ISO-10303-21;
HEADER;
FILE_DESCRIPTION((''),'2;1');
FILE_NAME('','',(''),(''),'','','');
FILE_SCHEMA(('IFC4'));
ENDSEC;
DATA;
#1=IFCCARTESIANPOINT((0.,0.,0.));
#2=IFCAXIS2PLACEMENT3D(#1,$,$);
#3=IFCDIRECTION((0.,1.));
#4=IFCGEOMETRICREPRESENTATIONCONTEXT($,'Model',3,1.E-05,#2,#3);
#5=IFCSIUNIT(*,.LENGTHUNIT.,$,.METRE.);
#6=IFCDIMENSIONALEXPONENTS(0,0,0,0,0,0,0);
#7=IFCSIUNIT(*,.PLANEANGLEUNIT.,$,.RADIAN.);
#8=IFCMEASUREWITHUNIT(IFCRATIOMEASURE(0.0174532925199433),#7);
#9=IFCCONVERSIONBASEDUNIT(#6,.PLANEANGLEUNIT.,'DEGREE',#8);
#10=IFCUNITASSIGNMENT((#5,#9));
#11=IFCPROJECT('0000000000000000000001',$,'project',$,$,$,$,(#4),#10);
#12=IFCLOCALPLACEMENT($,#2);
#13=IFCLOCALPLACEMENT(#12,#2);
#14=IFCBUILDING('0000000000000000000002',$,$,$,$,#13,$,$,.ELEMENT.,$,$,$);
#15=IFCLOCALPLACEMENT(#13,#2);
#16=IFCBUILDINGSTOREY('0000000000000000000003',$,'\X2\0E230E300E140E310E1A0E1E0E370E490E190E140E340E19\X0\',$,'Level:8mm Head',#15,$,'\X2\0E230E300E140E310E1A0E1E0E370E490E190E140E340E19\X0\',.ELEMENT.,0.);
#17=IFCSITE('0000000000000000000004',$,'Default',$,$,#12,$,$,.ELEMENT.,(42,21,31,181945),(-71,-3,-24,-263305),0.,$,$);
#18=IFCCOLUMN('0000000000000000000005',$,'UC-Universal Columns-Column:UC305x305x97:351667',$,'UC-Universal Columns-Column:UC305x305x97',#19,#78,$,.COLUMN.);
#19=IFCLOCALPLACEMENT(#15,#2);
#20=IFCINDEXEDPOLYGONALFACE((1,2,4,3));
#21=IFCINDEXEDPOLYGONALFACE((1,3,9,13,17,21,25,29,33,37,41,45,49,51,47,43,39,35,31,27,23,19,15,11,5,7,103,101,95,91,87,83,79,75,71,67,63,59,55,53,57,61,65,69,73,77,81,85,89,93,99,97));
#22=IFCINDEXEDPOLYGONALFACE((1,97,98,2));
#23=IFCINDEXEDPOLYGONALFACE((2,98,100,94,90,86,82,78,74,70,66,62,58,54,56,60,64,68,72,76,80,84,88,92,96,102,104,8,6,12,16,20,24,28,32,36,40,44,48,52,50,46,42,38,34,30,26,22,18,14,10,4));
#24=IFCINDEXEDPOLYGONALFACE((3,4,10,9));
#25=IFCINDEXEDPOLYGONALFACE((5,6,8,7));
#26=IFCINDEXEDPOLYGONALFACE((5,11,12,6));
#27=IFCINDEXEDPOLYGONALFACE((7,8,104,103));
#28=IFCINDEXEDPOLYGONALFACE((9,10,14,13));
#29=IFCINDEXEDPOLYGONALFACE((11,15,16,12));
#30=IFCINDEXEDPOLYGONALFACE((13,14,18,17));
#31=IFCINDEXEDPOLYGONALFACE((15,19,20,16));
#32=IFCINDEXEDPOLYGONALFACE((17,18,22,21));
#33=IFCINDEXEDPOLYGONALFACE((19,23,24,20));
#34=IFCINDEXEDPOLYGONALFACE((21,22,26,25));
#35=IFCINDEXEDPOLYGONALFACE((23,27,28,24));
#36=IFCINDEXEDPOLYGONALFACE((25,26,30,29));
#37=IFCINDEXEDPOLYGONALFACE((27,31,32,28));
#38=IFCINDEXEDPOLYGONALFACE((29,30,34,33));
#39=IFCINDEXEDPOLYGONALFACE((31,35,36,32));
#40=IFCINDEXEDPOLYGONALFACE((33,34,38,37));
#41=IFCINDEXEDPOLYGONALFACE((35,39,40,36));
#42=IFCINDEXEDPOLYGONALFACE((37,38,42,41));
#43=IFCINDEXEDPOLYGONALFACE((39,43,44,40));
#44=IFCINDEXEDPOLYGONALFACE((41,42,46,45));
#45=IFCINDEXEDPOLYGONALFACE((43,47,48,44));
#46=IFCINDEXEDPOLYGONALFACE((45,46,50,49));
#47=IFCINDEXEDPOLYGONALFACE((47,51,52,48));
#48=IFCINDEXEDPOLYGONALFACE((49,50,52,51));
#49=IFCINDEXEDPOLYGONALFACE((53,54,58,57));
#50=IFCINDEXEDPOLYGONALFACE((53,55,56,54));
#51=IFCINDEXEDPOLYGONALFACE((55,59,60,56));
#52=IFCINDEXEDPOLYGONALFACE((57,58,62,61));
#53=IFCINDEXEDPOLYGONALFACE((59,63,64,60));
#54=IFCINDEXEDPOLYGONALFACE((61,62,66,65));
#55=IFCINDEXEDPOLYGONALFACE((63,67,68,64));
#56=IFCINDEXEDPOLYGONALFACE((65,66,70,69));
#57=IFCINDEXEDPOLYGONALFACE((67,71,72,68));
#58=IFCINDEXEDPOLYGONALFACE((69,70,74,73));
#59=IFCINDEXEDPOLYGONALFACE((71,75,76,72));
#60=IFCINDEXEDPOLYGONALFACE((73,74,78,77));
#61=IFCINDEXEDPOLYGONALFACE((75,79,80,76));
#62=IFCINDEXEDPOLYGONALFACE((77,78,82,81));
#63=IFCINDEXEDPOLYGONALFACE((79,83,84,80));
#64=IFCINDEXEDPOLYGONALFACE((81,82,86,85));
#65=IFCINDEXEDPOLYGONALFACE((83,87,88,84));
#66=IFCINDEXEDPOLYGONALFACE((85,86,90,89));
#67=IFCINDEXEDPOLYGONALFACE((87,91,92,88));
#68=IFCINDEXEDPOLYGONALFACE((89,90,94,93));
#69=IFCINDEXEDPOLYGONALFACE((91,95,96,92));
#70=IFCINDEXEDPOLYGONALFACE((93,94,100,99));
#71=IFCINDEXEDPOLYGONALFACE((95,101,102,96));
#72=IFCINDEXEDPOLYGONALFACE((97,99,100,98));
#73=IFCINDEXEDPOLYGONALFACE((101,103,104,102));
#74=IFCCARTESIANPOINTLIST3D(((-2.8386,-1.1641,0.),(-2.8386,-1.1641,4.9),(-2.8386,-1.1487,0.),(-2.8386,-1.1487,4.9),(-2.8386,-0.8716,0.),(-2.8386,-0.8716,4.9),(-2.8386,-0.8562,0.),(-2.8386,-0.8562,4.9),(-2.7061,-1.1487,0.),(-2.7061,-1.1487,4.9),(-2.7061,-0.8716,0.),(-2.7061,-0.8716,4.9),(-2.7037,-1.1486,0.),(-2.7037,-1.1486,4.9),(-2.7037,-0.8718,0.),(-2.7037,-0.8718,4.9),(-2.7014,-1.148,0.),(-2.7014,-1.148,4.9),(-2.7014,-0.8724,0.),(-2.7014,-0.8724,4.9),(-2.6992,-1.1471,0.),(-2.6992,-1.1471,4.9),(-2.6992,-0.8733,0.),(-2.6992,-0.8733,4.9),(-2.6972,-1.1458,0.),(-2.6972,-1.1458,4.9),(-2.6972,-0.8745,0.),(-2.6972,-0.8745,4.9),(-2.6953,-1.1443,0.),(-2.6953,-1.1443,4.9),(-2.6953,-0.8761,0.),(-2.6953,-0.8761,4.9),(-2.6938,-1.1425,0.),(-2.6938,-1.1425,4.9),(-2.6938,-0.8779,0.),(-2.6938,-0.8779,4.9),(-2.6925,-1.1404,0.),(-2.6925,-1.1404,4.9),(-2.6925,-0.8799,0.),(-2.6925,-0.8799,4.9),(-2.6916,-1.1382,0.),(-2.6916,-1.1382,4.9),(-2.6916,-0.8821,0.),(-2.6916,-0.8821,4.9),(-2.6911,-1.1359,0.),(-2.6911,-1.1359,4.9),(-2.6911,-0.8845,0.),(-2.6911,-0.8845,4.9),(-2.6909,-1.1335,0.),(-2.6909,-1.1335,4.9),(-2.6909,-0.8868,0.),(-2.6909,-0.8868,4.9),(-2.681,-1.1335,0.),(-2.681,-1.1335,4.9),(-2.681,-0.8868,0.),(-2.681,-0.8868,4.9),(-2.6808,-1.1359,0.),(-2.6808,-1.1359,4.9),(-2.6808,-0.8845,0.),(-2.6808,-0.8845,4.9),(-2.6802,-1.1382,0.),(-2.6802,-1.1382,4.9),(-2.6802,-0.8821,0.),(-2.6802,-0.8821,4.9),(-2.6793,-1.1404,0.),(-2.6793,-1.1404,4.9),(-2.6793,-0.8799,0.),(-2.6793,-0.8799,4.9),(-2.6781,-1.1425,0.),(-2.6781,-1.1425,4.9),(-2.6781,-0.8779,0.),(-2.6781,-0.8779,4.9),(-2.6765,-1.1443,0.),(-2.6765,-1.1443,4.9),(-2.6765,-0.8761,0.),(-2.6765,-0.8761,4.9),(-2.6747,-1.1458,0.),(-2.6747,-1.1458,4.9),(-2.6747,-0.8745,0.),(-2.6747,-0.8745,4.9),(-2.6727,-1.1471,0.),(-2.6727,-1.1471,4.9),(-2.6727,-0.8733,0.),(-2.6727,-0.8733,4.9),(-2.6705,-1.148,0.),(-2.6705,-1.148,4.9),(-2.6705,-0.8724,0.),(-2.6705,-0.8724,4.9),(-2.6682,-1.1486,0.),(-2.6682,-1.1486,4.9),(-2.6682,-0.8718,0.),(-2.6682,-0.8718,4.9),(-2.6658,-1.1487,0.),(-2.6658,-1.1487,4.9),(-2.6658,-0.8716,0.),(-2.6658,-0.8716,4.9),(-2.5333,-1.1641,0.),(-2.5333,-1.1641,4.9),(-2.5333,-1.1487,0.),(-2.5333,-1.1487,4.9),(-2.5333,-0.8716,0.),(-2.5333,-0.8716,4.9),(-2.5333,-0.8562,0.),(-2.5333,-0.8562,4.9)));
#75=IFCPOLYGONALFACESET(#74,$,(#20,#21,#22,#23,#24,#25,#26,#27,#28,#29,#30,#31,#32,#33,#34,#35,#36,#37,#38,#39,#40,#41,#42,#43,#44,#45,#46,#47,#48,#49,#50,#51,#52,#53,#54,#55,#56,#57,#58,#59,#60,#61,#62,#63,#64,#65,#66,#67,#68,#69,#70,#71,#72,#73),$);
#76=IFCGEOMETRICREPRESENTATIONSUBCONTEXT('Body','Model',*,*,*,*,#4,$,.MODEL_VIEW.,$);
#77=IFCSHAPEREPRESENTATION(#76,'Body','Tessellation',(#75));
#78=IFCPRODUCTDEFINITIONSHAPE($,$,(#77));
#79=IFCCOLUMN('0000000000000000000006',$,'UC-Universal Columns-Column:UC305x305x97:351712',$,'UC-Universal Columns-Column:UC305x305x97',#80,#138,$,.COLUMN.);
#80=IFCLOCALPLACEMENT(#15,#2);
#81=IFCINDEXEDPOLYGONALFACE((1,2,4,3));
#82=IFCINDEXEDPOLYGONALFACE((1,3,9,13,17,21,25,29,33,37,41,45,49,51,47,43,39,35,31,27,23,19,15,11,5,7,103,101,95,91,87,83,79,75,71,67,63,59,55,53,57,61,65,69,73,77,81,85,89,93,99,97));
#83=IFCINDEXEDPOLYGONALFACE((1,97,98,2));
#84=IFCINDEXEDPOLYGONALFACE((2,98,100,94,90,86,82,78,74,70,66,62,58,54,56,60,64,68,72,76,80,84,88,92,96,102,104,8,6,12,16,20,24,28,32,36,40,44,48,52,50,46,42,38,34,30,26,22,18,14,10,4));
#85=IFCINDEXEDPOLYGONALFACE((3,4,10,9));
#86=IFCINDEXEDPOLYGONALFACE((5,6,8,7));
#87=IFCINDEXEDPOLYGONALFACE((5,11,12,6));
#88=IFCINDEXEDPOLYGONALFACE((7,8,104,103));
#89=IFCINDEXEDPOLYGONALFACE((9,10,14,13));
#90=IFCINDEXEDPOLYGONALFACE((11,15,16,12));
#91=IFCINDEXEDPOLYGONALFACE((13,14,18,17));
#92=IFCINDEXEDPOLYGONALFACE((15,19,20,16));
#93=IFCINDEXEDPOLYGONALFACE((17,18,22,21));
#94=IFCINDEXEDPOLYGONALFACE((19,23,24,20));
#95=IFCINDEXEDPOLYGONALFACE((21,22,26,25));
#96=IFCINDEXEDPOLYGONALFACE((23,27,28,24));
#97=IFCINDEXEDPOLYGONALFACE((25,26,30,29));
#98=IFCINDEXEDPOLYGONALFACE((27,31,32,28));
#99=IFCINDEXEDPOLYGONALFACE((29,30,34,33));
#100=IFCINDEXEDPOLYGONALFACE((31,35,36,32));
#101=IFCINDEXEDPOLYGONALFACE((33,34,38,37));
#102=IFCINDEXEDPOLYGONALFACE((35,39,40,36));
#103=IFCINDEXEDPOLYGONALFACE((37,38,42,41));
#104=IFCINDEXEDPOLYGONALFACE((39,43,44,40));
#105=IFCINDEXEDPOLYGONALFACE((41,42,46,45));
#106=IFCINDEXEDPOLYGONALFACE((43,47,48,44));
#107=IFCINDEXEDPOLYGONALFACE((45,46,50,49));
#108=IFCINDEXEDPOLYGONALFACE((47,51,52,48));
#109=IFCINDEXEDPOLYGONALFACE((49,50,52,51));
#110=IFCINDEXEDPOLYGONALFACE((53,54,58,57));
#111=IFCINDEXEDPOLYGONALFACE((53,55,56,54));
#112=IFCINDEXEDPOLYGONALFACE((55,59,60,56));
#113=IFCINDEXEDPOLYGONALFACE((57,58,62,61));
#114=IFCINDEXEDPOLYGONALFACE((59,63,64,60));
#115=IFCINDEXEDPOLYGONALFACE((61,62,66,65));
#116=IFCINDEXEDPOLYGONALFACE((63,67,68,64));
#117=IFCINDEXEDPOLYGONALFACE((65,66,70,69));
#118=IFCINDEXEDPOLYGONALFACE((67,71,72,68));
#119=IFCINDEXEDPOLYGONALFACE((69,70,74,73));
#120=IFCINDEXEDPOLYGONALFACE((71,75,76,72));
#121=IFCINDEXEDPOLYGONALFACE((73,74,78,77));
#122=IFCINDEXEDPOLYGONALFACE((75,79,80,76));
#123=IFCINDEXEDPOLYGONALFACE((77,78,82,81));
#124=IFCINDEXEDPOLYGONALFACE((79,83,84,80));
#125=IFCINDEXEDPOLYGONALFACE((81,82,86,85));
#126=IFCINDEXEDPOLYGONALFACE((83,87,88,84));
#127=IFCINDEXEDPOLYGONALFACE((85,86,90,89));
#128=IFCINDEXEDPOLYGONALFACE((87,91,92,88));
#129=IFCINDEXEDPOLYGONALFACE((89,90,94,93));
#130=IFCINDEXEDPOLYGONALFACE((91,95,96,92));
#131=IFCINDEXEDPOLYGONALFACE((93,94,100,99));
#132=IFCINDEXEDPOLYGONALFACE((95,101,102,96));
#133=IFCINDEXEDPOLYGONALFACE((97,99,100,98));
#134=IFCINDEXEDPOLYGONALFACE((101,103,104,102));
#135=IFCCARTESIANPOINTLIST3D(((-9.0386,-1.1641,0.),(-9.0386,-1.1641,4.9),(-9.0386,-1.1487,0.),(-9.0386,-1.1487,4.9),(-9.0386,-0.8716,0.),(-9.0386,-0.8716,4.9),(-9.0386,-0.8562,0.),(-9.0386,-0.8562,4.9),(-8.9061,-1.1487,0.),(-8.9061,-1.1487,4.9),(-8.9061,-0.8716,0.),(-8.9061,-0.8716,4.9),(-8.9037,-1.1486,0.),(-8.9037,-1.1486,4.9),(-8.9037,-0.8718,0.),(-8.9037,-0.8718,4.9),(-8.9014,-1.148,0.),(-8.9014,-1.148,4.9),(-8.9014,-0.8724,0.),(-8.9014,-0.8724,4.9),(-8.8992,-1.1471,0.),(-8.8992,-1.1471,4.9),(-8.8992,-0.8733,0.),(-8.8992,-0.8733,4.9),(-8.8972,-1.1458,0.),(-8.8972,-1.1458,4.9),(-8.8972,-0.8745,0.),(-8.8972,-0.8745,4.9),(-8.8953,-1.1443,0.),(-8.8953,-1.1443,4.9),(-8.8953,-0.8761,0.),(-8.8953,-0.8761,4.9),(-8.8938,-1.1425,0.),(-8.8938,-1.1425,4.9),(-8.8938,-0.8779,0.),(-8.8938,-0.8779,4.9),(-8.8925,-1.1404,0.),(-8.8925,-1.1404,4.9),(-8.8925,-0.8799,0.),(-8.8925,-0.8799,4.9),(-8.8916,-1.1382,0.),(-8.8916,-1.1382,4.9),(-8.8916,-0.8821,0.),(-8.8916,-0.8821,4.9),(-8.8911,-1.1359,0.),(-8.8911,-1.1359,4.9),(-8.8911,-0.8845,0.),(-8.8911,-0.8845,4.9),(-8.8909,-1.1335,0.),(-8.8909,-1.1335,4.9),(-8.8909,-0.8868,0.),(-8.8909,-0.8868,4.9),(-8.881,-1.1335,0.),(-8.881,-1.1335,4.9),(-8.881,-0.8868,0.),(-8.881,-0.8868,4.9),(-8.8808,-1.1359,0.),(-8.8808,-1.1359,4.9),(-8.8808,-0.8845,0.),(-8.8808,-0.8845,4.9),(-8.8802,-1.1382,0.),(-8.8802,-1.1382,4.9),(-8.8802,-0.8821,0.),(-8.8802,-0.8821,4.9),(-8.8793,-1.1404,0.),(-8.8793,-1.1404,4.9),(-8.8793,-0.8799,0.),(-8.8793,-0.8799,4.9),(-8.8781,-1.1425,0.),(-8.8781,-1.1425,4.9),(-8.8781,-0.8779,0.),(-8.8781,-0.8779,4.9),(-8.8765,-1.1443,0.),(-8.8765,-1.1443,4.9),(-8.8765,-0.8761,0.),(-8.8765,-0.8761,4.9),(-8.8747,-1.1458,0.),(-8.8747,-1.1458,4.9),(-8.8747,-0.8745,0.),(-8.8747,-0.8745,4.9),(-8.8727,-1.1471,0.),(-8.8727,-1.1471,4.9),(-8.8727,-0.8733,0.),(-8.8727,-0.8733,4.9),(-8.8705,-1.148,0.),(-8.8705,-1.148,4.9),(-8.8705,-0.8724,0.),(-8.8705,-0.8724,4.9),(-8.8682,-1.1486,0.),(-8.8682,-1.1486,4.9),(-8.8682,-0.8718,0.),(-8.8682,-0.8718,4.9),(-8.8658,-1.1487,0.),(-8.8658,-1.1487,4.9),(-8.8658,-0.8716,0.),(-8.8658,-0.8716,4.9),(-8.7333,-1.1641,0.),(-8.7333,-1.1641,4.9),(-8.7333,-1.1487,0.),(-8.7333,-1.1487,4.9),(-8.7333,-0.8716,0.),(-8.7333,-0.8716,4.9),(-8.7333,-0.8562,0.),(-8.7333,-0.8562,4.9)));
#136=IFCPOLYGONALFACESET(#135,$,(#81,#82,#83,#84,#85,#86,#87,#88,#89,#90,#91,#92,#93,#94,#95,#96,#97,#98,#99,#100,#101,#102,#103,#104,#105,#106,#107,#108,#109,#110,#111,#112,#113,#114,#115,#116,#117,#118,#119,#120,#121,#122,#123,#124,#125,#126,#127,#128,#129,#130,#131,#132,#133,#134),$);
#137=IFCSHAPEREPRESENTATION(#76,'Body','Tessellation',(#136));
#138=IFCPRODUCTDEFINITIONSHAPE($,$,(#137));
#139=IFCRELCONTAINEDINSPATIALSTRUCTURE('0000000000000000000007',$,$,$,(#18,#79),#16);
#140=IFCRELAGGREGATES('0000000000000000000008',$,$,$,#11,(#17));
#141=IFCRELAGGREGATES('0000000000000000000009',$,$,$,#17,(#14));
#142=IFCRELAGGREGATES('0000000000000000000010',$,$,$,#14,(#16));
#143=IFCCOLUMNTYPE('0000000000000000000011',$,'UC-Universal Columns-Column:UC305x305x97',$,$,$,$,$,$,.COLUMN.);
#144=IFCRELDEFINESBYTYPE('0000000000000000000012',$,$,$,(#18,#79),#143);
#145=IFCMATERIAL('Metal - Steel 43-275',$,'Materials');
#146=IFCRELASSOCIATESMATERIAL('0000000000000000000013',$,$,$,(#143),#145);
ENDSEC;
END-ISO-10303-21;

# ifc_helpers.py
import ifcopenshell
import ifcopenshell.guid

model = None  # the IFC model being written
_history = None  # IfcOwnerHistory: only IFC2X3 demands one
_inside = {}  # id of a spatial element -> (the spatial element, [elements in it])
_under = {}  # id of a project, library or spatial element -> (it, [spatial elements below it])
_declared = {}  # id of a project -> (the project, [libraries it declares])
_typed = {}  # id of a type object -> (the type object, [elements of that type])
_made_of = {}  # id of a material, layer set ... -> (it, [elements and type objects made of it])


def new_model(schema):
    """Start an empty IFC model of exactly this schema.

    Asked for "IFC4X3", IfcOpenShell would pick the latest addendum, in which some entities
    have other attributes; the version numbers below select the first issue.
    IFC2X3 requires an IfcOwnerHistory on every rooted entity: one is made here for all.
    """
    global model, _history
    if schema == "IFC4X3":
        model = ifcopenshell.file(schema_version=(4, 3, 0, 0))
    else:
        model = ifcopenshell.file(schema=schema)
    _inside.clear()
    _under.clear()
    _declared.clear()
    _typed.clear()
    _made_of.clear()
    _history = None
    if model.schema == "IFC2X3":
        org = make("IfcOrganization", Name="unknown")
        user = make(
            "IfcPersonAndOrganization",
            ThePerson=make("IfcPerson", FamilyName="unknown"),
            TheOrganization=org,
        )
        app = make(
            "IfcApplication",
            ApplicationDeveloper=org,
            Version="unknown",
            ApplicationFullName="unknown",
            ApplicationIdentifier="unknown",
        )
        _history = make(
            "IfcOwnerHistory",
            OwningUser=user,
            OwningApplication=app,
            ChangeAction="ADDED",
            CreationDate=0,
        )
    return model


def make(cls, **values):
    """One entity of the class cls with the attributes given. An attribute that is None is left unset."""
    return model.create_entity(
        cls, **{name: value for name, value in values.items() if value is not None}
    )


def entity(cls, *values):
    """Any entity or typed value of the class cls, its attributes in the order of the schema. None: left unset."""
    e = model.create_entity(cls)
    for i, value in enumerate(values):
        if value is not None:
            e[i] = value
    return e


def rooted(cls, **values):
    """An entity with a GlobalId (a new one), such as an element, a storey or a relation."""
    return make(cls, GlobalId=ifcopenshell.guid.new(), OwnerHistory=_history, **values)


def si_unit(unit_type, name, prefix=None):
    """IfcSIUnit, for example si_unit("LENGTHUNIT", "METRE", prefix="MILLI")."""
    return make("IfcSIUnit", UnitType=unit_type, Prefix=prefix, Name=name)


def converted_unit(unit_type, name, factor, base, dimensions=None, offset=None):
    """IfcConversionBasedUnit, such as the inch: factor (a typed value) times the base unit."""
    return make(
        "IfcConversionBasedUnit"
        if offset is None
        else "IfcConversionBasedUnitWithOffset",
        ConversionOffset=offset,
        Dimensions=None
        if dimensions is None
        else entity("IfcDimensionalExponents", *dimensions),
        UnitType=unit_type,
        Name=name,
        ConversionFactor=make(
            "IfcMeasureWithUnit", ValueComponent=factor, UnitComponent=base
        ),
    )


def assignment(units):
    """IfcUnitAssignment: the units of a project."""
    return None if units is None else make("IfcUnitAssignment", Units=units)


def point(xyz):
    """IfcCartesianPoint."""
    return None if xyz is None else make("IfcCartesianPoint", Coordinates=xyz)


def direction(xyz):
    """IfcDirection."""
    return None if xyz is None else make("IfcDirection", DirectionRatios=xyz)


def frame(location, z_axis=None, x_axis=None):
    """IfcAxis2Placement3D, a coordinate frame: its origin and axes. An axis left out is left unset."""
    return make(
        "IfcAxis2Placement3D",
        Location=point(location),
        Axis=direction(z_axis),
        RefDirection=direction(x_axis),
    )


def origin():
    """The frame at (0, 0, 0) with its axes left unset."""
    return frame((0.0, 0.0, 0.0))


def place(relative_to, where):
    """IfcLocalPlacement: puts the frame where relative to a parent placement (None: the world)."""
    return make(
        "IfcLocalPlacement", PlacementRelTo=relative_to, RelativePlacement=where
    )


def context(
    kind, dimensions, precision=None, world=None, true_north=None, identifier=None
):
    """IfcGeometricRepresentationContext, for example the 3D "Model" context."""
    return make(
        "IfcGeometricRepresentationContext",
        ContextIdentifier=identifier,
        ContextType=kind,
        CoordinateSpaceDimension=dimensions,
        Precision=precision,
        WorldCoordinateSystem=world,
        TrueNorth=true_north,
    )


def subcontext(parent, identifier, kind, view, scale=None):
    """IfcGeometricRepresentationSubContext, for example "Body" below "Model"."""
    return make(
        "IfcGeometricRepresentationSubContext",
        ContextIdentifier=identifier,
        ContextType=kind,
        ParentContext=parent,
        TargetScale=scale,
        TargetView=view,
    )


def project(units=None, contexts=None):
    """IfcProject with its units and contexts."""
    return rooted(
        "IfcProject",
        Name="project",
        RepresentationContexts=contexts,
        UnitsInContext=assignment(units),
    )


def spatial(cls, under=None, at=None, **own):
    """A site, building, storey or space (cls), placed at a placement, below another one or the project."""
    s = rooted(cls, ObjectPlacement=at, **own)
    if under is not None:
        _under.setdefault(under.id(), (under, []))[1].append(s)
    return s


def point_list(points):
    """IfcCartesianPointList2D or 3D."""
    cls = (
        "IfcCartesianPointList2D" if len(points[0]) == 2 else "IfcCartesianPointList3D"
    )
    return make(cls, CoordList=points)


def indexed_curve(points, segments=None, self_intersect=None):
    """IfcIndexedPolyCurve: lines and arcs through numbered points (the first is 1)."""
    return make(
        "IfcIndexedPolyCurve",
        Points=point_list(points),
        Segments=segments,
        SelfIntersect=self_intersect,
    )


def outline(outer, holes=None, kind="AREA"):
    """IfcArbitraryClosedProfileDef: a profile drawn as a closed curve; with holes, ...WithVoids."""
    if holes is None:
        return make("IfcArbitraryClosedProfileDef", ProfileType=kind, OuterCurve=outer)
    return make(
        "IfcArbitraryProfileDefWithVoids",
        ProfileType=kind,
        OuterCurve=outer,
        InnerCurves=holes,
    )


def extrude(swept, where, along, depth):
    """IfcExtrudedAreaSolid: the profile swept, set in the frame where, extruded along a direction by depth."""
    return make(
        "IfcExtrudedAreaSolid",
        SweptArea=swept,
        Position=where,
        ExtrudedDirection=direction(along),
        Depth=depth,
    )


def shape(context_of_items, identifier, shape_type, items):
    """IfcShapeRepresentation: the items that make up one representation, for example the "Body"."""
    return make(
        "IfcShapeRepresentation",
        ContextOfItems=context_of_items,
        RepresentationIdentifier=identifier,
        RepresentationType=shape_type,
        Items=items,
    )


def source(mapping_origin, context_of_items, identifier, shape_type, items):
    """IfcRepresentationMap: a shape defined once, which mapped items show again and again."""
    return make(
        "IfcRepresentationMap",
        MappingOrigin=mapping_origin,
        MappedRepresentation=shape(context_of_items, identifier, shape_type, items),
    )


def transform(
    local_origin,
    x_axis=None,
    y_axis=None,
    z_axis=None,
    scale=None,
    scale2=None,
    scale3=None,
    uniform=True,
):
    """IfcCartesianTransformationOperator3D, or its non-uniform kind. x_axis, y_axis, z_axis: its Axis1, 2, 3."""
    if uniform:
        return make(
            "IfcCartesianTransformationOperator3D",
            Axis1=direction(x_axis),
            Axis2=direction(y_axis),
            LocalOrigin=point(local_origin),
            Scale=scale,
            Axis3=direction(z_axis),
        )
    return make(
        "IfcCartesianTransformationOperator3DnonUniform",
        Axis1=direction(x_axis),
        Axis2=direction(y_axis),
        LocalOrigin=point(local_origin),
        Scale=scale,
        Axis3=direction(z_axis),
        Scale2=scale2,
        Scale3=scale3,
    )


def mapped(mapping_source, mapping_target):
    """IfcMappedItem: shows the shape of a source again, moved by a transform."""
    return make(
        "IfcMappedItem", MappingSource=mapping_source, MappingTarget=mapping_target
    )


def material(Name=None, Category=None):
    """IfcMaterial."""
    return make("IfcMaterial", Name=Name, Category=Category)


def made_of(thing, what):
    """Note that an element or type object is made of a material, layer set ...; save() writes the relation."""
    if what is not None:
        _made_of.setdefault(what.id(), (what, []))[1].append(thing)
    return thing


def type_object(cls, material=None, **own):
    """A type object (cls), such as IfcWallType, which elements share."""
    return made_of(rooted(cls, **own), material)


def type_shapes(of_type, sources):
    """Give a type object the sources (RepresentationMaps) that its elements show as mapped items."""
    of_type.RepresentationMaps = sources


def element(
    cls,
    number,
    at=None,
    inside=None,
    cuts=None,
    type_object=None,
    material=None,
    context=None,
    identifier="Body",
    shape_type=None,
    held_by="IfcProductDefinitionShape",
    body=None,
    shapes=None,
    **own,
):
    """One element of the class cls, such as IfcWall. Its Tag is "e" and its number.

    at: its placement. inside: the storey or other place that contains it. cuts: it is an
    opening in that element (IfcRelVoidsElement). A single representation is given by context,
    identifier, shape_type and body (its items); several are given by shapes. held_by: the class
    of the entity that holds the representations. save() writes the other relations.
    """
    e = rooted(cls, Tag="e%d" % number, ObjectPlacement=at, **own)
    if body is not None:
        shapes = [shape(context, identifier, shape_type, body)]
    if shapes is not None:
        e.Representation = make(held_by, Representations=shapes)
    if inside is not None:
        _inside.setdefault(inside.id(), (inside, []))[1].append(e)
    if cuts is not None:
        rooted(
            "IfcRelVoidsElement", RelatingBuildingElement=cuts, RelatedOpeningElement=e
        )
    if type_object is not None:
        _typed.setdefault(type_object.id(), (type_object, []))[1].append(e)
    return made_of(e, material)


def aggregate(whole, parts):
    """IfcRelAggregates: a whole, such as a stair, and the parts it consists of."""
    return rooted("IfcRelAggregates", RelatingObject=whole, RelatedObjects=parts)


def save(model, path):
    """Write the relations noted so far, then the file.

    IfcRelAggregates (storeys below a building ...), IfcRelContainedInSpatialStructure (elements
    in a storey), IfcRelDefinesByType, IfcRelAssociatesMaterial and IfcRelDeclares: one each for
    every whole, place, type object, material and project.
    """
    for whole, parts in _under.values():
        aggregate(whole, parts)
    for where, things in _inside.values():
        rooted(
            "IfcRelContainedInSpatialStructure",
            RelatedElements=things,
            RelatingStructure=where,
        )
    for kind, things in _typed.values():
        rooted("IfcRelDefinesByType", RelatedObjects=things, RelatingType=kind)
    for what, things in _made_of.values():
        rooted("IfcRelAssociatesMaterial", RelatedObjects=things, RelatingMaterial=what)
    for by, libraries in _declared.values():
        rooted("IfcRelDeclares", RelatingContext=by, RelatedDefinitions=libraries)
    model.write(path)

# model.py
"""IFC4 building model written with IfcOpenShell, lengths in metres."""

from ifc_helpers import new_model, entity, si_unit, converted_unit, direction, frame, origin, place, context, subcontext, project, spatial, indexed_curve, outline, extrude, source, transform, mapped, material, type_object, type_shapes, element, save


model = new_model("IFC4")

# Units and contexts
model_context = context("Model", 3, precision=1e-05, world=origin(), true_north=direction((0.0, 1.0)))
body_context = subcontext(model_context, "Body", "Model", "MODEL_VIEW")
ifc_project = project(units=[si_unit("LENGTHUNIT", "METRE"), converted_unit("PLANEANGLEUNIT", "DEGREE", entity("IfcRatioMeasure", 0.0174532925199433), si_unit("PLANEANGLEUNIT", "RADIAN"), dimensions=[0, 0, 0, 0, 0, 0, 0])], contexts=[model_context])

# Site, building, storey
site_placement = place(None, origin())
site = spatial("IfcSite", under=ifc_project, at=site_placement, Name="Default", CompositionType="ELEMENT", RefLatitude=(42, 21, 31, 181945), RefLongitude=(-71, -3, -24, -263305), RefElevation=0.0)
building_placement = place(site_placement, origin())
building = spatial("IfcBuilding", under=site, at=building_placement, CompositionType="ELEMENT")
storey_placement = place(building_placement, origin())
storey = spatial("IfcBuildingStorey", under=building, at=storey_placement, Name="ระดับพื้นดิน", ObjectType="Level:8mm Head", LongName="ระดับพื้นดิน", CompositionType="ELEMENT", Elevation=0.0)

# Columns
ifc_material_1 = material(Name="Metal - Steel 43-275", Category="Materials")
column_type_1 = type_object("IfcColumnType", Name="UC-Universal Columns-Column:UC305x305x97", PredefinedType="COLUMN", material=ifc_material_1)
shared_shape_1 = source(origin(), body_context, "Body", "SweptSolid", [
    extrude(outline(indexed_curve([(-0.154, -0.1527), (-0.1386, -0.1527), (-0.1386, -0.0202), (-0.1384, -0.0178), (-0.1378, -0.0155), (-0.1369, -0.0132), (-0.1356, -0.0112), (-0.1341, -0.0094), (-0.1323, -0.0079), (-0.1303, -0.0066), (-0.128, -0.0057), (-0.1257, -0.0051), (-0.1234, -0.0049), (0.1234, -0.0049), (0.1257, -0.0051), (0.128, -0.0057), (0.1303, -0.0066), (0.1323, -0.0079), (0.1341, -0.0094), (0.1356, -0.0112), (0.1369, -0.0132), (0.1378, -0.0155), (0.1384, -0.0178), (0.1386, -0.0201), (0.1386, -0.1527), (0.154, -0.1527), (0.154, 0.1527), (0.1386, 0.1527), (0.1386, 0.0202), (0.1384, 0.0178), (0.1378, 0.0155), (0.1369, 0.0132), (0.1356, 0.0112), (0.1341, 0.0094), (0.1323, 0.0079), (0.1303, 0.0066), (0.128, 0.0057), (0.1257, 0.0051), (0.1234, 0.005), (-0.1234, 0.005), (-0.1257, 0.0051), (-0.128, 0.0057), (-0.1303, 0.0066), (-0.1323, 0.0079), (-0.1341, 0.0094), (-0.1356, 0.0112), (-0.1369, 0.0132), (-0.1378, 0.0155), (-0.1384, 0.0178), (-0.1386, 0.0202), (-0.1386, 0.1527), (-0.154, 0.1527), (-0.154, -0.1527)], self_intersect=False)), frame((0.0, 0.0, 0.0), z_axis=(0.0, 0.0, 1.0), x_axis=(0.0, -1.0, 0.0)), (0.0, 0.0, 1.0), 4.9),
])
type_shapes(column_type_1, [shared_shape_1])
for number, where, name in (
    (1, (-2.6859, -1.0102, 0.0), "UC-Universal Columns-Column:UC305x305x97:351667"),
    (2, (-8.8859, -1.0102, 0.0), "UC-Universal Columns-Column:UC305x305x97:351712"),
):
    element("IfcColumn", number, at=place(storey_placement, frame(where)), inside=storey, type_object=column_type_1, Name=name, ObjectType="UC-Universal Columns-Column:UC305x305x97", PredefinedType="COLUMN", context=body_context, shape_type="MappedRepresentation", body=[
        mapped(shared_shape_1, transform((0.0, 0.0, 0.0), scale=1.0)),
    ])

save(model, "model.ifc")
